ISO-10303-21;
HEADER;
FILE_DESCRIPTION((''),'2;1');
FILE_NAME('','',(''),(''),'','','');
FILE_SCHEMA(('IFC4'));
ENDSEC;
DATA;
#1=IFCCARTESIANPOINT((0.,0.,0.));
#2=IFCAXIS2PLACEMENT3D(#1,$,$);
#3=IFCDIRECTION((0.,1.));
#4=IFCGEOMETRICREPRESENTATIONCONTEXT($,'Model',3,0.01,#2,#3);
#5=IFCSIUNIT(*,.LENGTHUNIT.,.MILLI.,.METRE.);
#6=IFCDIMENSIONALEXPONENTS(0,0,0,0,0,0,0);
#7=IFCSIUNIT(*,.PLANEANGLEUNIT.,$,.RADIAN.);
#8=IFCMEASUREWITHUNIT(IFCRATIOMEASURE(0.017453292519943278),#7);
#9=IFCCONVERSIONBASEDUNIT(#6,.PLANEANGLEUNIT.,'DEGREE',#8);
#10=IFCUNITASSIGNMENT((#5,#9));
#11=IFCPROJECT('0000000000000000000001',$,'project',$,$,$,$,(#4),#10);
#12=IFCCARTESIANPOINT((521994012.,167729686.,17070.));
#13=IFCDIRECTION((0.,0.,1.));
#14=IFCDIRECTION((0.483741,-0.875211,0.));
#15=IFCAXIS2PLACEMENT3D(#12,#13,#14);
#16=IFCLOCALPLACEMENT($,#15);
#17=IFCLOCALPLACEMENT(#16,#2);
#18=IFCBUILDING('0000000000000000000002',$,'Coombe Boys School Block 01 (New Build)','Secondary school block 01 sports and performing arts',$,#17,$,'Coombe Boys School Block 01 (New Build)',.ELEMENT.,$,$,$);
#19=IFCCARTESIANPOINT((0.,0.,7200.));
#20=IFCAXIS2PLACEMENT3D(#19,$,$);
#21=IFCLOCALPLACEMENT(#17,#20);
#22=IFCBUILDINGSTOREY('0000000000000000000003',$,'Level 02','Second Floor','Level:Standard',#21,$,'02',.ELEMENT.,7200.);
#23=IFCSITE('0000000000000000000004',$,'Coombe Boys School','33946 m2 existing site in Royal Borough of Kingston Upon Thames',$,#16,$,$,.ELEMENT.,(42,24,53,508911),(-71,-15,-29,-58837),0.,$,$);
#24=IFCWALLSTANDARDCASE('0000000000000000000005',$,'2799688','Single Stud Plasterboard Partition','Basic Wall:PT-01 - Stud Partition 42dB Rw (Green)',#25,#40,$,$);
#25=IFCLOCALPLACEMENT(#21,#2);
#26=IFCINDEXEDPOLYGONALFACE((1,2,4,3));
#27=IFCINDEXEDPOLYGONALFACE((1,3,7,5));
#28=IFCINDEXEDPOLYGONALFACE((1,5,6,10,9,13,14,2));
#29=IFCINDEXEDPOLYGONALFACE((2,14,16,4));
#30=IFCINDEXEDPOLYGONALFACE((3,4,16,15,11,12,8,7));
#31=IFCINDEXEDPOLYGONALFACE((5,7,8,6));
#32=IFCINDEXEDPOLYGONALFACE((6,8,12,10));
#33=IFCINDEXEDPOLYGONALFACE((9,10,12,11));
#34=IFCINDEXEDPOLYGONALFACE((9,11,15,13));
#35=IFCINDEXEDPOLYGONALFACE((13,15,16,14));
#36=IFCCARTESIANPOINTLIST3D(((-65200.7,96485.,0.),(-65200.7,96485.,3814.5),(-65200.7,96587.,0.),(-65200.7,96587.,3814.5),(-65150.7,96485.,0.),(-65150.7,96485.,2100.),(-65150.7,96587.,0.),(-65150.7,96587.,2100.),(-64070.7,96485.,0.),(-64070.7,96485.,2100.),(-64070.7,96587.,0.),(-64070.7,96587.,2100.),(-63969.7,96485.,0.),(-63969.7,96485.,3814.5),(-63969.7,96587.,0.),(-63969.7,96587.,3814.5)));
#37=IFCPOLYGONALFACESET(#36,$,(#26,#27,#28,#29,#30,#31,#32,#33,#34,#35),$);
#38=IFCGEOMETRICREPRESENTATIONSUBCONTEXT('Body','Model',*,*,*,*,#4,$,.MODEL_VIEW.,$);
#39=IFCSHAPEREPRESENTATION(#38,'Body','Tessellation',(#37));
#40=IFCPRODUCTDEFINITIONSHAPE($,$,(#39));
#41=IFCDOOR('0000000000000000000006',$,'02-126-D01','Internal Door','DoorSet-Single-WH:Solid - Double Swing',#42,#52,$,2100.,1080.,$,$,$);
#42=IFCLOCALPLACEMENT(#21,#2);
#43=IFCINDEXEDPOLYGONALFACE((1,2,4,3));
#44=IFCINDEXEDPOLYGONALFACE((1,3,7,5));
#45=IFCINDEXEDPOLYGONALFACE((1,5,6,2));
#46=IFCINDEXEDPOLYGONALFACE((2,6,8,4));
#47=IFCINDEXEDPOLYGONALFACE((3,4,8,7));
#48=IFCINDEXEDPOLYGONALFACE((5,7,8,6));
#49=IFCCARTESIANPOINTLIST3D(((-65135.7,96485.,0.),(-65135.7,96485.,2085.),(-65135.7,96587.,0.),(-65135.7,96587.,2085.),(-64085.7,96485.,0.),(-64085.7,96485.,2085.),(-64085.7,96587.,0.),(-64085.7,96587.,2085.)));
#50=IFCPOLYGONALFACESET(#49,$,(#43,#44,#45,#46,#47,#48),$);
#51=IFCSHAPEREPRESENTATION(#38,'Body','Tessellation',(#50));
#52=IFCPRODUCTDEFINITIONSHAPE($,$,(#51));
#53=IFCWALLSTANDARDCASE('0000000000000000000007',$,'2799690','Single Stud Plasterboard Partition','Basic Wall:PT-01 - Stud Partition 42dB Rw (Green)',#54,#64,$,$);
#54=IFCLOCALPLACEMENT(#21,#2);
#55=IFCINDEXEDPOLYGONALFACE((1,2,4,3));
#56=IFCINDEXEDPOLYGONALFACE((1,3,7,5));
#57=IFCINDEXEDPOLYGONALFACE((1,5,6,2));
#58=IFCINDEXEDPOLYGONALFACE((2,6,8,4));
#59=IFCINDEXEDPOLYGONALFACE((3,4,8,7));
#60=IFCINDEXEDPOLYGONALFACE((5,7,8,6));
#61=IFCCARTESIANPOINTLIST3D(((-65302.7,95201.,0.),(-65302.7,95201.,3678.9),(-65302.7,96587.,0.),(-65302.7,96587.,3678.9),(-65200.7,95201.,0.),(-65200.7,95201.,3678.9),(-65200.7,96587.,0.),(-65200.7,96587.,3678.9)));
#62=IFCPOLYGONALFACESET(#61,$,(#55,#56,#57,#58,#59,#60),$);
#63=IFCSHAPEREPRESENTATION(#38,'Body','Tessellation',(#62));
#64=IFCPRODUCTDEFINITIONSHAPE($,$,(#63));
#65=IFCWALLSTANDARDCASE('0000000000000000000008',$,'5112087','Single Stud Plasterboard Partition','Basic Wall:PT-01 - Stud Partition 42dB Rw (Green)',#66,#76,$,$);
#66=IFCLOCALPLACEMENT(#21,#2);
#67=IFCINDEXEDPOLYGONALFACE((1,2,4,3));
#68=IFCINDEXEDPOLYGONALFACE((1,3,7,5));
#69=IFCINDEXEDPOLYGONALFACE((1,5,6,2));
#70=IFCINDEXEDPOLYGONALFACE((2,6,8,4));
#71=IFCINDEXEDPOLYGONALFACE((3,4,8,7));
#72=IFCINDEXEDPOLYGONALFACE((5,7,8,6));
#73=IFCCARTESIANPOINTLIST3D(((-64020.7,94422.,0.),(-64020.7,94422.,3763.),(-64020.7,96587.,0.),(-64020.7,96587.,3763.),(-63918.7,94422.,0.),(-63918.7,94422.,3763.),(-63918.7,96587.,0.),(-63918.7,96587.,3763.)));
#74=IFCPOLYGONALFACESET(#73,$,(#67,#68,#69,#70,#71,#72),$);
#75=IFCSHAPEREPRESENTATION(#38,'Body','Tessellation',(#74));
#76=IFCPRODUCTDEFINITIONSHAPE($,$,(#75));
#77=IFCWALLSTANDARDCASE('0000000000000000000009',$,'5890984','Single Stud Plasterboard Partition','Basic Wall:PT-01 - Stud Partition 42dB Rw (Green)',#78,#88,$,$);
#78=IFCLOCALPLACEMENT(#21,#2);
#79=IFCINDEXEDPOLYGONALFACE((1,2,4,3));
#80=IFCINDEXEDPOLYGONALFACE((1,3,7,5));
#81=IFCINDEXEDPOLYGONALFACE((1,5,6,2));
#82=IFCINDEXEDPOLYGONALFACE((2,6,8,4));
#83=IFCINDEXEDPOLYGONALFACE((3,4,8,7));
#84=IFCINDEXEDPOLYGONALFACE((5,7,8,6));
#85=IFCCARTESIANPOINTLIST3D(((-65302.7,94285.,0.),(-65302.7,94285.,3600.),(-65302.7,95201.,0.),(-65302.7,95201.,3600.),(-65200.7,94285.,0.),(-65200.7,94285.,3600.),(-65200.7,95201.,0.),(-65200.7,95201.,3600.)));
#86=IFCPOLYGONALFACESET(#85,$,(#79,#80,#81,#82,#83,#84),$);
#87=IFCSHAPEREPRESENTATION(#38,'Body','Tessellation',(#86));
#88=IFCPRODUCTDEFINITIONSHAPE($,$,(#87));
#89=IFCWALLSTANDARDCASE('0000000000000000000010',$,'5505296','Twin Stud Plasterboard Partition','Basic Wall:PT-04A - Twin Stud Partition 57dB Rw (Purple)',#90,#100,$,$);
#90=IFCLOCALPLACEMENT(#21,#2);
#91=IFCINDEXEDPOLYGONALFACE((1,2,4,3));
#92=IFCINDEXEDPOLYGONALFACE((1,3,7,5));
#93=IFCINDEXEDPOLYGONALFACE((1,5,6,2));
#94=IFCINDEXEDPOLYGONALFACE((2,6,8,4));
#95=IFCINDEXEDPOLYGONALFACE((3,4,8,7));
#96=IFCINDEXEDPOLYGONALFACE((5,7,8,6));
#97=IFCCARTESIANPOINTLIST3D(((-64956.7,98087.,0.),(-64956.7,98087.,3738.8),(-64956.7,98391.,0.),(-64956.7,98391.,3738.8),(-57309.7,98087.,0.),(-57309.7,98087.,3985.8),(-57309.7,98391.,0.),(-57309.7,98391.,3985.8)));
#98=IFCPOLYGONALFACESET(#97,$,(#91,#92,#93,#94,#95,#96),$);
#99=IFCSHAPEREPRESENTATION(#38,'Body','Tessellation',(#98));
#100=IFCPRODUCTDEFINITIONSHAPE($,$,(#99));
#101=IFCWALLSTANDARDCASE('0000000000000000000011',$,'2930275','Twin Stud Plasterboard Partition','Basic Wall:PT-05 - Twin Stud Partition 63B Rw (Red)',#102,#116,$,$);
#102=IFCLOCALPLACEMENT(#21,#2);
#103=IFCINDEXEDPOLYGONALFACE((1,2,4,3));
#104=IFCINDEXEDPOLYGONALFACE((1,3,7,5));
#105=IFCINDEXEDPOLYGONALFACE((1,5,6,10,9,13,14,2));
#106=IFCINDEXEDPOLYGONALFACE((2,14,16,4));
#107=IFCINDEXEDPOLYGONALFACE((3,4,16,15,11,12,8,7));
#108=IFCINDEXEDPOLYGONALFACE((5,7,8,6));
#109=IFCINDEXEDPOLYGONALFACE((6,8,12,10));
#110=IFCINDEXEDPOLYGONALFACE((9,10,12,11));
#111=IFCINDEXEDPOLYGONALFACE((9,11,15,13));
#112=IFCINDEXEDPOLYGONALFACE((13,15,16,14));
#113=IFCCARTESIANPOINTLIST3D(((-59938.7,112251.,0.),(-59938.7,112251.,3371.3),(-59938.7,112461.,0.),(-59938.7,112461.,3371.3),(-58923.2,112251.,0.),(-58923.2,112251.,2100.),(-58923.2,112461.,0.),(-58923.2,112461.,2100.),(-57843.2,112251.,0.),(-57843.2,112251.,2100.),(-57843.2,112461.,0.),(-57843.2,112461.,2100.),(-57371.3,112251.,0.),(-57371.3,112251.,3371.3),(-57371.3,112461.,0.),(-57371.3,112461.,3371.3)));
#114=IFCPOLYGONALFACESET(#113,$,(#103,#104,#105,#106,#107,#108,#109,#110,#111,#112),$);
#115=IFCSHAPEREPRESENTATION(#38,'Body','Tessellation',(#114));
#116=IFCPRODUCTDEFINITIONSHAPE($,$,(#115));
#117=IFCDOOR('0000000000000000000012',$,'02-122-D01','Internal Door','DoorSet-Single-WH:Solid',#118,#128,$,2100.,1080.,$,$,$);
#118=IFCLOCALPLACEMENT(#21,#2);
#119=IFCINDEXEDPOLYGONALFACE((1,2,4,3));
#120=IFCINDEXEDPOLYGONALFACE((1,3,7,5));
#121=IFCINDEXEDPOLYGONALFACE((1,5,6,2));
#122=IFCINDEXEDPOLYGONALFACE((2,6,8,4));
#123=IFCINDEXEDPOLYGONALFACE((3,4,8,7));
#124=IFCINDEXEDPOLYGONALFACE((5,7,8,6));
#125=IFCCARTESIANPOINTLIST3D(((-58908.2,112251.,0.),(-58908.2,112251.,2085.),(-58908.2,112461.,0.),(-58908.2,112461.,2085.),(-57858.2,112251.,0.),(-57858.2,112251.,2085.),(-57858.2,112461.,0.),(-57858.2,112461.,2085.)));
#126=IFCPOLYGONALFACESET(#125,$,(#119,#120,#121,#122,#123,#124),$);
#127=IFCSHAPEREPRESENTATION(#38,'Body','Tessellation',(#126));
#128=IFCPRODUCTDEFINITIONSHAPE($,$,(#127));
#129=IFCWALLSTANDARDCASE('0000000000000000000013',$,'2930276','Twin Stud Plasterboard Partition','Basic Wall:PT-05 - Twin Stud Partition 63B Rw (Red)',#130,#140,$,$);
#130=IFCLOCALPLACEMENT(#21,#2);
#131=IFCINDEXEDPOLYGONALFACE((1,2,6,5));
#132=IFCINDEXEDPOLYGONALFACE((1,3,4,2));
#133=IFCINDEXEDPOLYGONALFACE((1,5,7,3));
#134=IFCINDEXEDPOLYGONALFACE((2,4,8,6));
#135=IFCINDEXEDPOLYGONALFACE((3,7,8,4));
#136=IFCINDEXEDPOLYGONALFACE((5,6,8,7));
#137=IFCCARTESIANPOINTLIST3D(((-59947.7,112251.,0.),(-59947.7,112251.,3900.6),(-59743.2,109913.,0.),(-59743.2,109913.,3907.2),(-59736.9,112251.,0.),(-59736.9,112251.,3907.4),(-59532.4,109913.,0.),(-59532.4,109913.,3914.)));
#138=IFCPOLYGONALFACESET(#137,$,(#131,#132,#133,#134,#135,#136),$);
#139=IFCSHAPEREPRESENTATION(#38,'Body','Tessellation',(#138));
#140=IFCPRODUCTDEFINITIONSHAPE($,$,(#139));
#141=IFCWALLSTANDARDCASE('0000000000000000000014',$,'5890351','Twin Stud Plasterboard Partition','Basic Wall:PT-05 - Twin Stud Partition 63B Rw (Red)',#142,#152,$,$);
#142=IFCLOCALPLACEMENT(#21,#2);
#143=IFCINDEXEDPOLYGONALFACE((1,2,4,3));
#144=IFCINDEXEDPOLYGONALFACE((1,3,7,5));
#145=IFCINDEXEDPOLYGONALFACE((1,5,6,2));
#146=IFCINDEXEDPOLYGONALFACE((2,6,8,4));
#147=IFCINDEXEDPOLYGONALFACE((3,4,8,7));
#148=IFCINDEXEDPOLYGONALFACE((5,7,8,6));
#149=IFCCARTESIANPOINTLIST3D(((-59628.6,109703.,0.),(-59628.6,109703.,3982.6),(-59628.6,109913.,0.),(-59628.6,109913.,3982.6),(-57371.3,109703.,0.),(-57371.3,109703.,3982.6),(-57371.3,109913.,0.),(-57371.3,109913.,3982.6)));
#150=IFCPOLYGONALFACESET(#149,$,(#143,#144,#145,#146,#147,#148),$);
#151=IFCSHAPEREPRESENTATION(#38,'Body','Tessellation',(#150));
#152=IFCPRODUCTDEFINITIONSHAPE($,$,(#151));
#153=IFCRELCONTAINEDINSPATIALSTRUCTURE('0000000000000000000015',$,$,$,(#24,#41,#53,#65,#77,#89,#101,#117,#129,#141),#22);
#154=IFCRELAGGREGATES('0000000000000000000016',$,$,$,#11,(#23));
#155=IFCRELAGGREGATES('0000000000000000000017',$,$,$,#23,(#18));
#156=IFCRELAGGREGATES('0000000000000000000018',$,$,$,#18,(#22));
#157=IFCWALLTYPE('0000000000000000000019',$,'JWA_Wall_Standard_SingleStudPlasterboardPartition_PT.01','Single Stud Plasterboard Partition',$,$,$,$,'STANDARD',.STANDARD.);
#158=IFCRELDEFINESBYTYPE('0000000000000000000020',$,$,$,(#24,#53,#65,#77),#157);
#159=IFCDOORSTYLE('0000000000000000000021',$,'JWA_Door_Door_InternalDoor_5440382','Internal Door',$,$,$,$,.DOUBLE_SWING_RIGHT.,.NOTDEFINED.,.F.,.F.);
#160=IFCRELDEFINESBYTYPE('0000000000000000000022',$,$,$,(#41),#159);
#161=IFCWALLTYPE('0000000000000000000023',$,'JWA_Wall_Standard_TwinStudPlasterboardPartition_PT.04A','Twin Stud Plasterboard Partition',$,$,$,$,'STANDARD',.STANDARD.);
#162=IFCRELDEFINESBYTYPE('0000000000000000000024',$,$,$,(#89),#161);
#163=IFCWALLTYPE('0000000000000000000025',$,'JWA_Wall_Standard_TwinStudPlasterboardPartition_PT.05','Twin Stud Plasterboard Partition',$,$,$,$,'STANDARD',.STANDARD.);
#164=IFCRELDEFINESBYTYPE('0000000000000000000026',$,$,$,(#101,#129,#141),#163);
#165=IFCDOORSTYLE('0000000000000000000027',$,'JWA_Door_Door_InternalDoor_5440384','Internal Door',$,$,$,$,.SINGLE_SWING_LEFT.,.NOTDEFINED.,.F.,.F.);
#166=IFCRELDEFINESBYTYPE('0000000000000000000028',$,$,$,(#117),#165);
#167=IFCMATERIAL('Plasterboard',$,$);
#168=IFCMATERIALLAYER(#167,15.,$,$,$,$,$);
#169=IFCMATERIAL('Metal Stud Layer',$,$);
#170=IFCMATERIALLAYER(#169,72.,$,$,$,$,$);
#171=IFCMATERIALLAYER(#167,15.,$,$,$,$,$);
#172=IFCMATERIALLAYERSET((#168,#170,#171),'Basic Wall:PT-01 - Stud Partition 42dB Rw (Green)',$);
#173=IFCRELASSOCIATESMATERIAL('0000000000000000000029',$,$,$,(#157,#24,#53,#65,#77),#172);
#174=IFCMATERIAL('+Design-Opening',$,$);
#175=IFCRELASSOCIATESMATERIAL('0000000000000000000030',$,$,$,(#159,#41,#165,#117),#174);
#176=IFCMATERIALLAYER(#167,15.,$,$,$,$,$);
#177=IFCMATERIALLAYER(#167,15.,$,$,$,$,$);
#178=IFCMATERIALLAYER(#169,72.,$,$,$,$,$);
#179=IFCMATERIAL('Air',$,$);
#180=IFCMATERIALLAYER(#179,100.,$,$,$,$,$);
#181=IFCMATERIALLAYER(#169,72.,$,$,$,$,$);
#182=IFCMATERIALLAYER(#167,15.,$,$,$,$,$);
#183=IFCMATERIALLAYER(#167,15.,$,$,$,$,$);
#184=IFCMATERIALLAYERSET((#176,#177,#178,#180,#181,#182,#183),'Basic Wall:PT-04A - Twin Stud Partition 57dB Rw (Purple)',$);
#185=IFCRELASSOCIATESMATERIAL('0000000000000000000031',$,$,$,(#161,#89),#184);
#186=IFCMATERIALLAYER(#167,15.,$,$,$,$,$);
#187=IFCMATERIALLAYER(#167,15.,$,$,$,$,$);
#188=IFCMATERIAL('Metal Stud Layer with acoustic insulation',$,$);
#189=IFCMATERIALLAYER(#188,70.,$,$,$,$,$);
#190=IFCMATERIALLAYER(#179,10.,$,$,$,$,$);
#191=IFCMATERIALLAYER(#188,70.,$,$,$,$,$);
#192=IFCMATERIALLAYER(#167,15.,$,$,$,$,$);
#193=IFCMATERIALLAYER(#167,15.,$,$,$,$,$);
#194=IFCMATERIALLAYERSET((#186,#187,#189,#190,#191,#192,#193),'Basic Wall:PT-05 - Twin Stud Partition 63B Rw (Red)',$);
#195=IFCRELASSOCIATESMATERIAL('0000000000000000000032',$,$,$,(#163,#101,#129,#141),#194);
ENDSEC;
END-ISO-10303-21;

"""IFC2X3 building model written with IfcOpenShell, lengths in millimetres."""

from ifc_helpers import new_model, entity, si_unit, converted_unit, direction, frame, frame_2d, origin, origin_2d_with_axis, place, context, subcontext, project, spatial, polyline, rectangle, outline, extrude, clip, bounded_halfspace, source, transform, mapped, material, layer, layer_set, layer_usage, type_object, type_shapes, element, fill, save


model = new_model("IFC2X3")

# Units and contexts
model_context = context("Model", 3, precision=0.01, world=origin(), true_north=direction((0.0, 1.0)))
body_context = subcontext(model_context, "Body", "Model", "MODEL_VIEW")
ifc_project = project(units=[si_unit("LENGTHUNIT", "METRE", prefix="MILLI"), converted_unit("PLANEANGLEUNIT", "DEGREE", entity("IfcRatioMeasure", 0.017453292519943278), si_unit("PLANEANGLEUNIT", "RADIAN"), dimensions=[0, 0, 0, 0, 0, 0, 0])], contexts=[model_context])

# Site, building, storey
site_placement = place(None, frame((521994012.0, 167729686.0, 17070.0), z_axis=(0.0, 0.0, 1.0), x_axis=(0.483741, -0.875211, 0.0)))
site = spatial("IfcSite", under=ifc_project, at=site_placement, Name="Coombe Boys School", Description="33946 m2 existing site in Royal Borough of Kingston Upon Thames", CompositionType="ELEMENT", RefLatitude=(42, 24, 53, 508911), RefLongitude=(-71, -15, -29, -58837), RefElevation=0.0)
building_placement = place(site_placement, origin())
building = spatial("IfcBuilding", under=site, at=building_placement, Name="Coombe Boys School Block 01 (New Build)", Description="Secondary school block 01 sports and performing arts", LongName="Coombe Boys School Block 01 (New Build)", CompositionType="ELEMENT")
storey_placement = place(building_placement, frame((0.0, 0.0, 7200.0)))
storey = spatial("IfcBuildingStorey", under=building, at=storey_placement, Name="Level 02", Description="Second Floor", ObjectType="Level:Standard", LongName="02", CompositionType="ELEMENT", Elevation=7200.0)

# Wall, opening, door
ifc_material_1 = material(Name="Plasterboard")
ifc_layer_1 = layer(ifc_material_1, 15.0)
ifc_material_2 = material(Name="Metal Stud Layer")
ifc_layer_2 = layer(ifc_material_2, 72.0)
ifc_layer_3 = layer(ifc_material_1, 15.0)
ifc_layer_set_1 = layer_set([ifc_layer_1, ifc_layer_2, ifc_layer_3], Name="Basic Wall:PT-01 - Stud Partition 42dB Rw (Green)")
ifc_layer_usage_1 = layer_usage(ifc_layer_set_1, "AXIS2", "NEGATIVE", 51.0)
wall_type_1 = type_object("IfcWallType", Name="JWA_Wall_Standard_SingleStudPlasterboardPartition_PT.01", Description="Single Stud Plasterboard Partition", ElementType="STANDARD", PredefinedType="STANDARD", material=ifc_layer_set_1)
wall_1_placement = place(storey_placement, frame((-65200.7, 96536.0, 0.0)))
wall_1 = element("IfcWallStandardCase", 1, at=wall_1_placement, inside=storey, type_object=wall_type_1, material=ifc_layer_usage_1, Name="2799688", Description="Single Stud Plasterboard Partition", ObjectType="Basic Wall:PT-01 - Stud Partition 42dB Rw (Green)", context=body_context, shape_type="SweptSolid", body=[
    extrude(rectangle(XDim=1231.0, YDim=102.0, at=frame_2d((615.5, 0.0), x_axis=(-1.0, 0.0))), origin(), (0.0, 0.0, 1.0), 3814.5),
])
opening_1_placement = place(wall_1_placement, frame((65200.7, -96536.0, 0.0)))
opening_1 = element("IfcOpeningElement", 2, at=opening_1_placement, cuts=wall_1, ObjectType="Opening", context=body_context, shape_type="SweptSolid", body=[
    extrude(rectangle(XDim=2100.0, YDim=1080.0, at=frame_2d((0.0, 0.0), x_axis=(0.0, 1.0))), frame((-64610.7, 96485.0, 1050.0), z_axis=(0.0, 1.0, 0.0), x_axis=(1.0, 0.0, 0.0)), (0.0, 0.0, 1.0), 102.0),
])
ifc_material_3 = material(Name="+Design-Opening")
door_style_1 = type_object("IfcDoorStyle", Name="JWA_Door_Door_InternalDoor_5440382", Description="Internal Door", ConstructionType="NOTDEFINED", OperationType="DOUBLE_SWING_RIGHT", ParameterTakesPrecedence=False, Sizeable=False, material=ifc_material_3)
shared_shape_1 = source(origin(), body_context, "Body", "SweptSolid", [
    extrude(rectangle(XDim=102.0, YDim=1050.0, at=origin_2d_with_axis()), frame((125.0, 0.0, 0.0), z_axis=(0.0, 0.0, 1.0), x_axis=(0.0, 1.0, 0.0)), (0.0, 0.0, 1.0), 2085.0),
])
type_shapes(door_style_1, [shared_shape_1])
door_1_placement = place(opening_1_placement, frame((-64485.7, 96536.0, 0.0), z_axis=(0.0, 0.0, 1.0), x_axis=(-1.0, 0.0, 0.0)))
door_1 = element("IfcDoor", 3, at=door_1_placement, inside=storey, type_object=door_style_1, material=ifc_material_3, Name="02-126-D01", Description="Internal Door", ObjectType="DoorSet-Single-WH:Solid - Double Swing", OverallHeight=2100.0, OverallWidth=1080.0, context=body_context, shape_type="MappedRepresentation", body=[
    mapped(shared_shape_1, transform((0.0, 0.0, 0.0), scale=1.0)),
])
fill(opening_1, door_1)

# Walls
wall_2_placement = place(storey_placement, frame((-65251.7, 96587.0, 0.0), z_axis=(0.0, 0.0, 1.0), x_axis=(0.0, -1.0, 0.0)))
element("IfcWallStandardCase", 4, at=wall_2_placement, inside=storey, type_object=wall_type_1, material=ifc_layer_usage_1, Name="2799690", Description="Single Stud Plasterboard Partition", ObjectType="Basic Wall:PT-01 - Stud Partition 42dB Rw (Green)", context=body_context, shape_type="SweptSolid", body=[
    extrude(rectangle(XDim=1386.0, YDim=102.0, at=frame_2d((693.0, 0.0), x_axis=(-1.0, 0.0))), origin(), (0.0, 0.0, 1.0), 3678.9),
])
wall_3_placement = place(storey_placement, frame((-63969.7, 96587.0, 0.0), z_axis=(0.0, 0.0, 1.0), x_axis=(0.0, -1.0, 0.0)))
element("IfcWallStandardCase", 5, at=wall_3_placement, inside=storey, type_object=wall_type_1, material=ifc_layer_usage_1, Name="5112087", Description="Single Stud Plasterboard Partition", ObjectType="Basic Wall:PT-01 - Stud Partition 42dB Rw (Green)", context=body_context, shape_type="SweptSolid", body=[
    extrude(rectangle(XDim=2165.0, YDim=102.0, at=frame_2d((1082.5, 0.0), x_axis=(-1.0, 0.0))), origin(), (0.0, 0.0, 1.0), 3763.0),
])

# Walls
wall_4_placement = place(storey_placement, frame((-65251.7, 95201.0, 0.0), z_axis=(0.0, 0.0, 1.0), x_axis=(0.0, -1.0, 0.0)))
element("IfcWallStandardCase", 6, at=wall_4_placement, inside=storey, type_object=wall_type_1, material=ifc_layer_usage_1, Name="5890984", Description="Single Stud Plasterboard Partition", ObjectType="Basic Wall:PT-01 - Stud Partition 42dB Rw (Green)", context=body_context, shape_type="SweptSolid", body=[
    extrude(rectangle(XDim=916.0, YDim=102.0, at=frame_2d((458.0, 0.0), x_axis=(-1.0, 0.0))), origin(), (0.0, 0.0, 1.0), 3600.0),
])
ifc_layer_4 = layer(ifc_material_1, 15.0)
ifc_layer_5 = layer(ifc_material_1, 15.0)
ifc_layer_6 = layer(ifc_material_2, 72.0)
ifc_material_4 = material(Name="Air")
ifc_layer_7 = layer(ifc_material_4, 100.0)
ifc_layer_8 = layer(ifc_material_2, 72.0)
ifc_layer_9 = layer(ifc_material_1, 15.0)
ifc_layer_10 = layer(ifc_material_1, 15.0)
ifc_layer_set_2 = layer_set([ifc_layer_4, ifc_layer_5, ifc_layer_6, ifc_layer_7, ifc_layer_8, ifc_layer_9, ifc_layer_10], Name="Basic Wall:PT-04A - Twin Stud Partition 57dB Rw (Purple)")
ifc_layer_usage_2 = layer_usage(ifc_layer_set_2, "AXIS2", "NEGATIVE", 152.0)
wall_type_2 = type_object("IfcWallType", Name="JWA_Wall_Standard_TwinStudPlasterboardPartition_PT.04A", Description="Twin Stud Plasterboard Partition", ElementType="STANDARD", PredefinedType="STANDARD", material=ifc_layer_set_2)
wall_5_placement = place(storey_placement, frame((-64956.7, 98239.0, 0.0)))
element("IfcWallStandardCase", 7, at=wall_5_placement, inside=storey, type_object=wall_type_2, material=ifc_layer_usage_2, Name="5505296", Description="Twin Stud Plasterboard Partition", ObjectType="Basic Wall:PT-04A - Twin Stud Partition 57dB Rw (Purple)", context=body_context, shape_type="Clipping", body=[
    clip(extrude(rectangle(XDim=7647.0, YDim=304.0, at=frame_2d((3823.5, 0.0), x_axis=(-1.0, 0.0))), origin(), (0.0, 0.0, 1.0), 3985.8), bounded_halfspace(frame((0.0, -152.0, 3738.8), z_axis=(-0.032283, 0.0, 0.999479), x_axis=(0.0, -1.0, 0.0)), False, frame((0.0, -152.0, 3738.8)), polyline([(0.0, 0.0), (7647.0, 0.0), (7647.0, 304.0), (0.0, 304.0), (0.0, 0.0)]))),
])

# Wall, opening, door
ifc_layer_11 = layer(ifc_material_1, 15.0)
ifc_layer_12 = layer(ifc_material_1, 15.0)
ifc_material_5 = material(Name="Metal Stud Layer with acoustic insulation")
ifc_layer_13 = layer(ifc_material_5, 70.0)
ifc_layer_14 = layer(ifc_material_4, 10.0)
ifc_layer_15 = layer(ifc_material_5, 70.0)
ifc_layer_16 = layer(ifc_material_1, 15.0)
ifc_layer_17 = layer(ifc_material_1, 15.0)
ifc_layer_set_3 = layer_set([ifc_layer_11, ifc_layer_12, ifc_layer_13, ifc_layer_14, ifc_layer_15, ifc_layer_16, ifc_layer_17], Name="Basic Wall:PT-05 - Twin Stud Partition 63B Rw (Red)")
ifc_layer_usage_3 = layer_usage(ifc_layer_set_3, "AXIS2", "NEGATIVE", 105.0)
wall_type_3 = type_object("IfcWallType", Name="JWA_Wall_Standard_TwinStudPlasterboardPartition_PT.05", Description="Twin Stud Plasterboard Partition", ElementType="STANDARD", PredefinedType="STANDARD", material=ifc_layer_set_3)
wall_6_placement = place(storey_placement, frame((-57371.3, 112356.0, 0.0), z_axis=(0.0, 0.0, 1.0), x_axis=(-1.0, 0.0, 0.0)))
wall_6 = element("IfcWallStandardCase", 8, at=wall_6_placement, inside=storey, type_object=wall_type_3, material=ifc_layer_usage_3, Name="2930275", Description="Twin Stud Plasterboard Partition", ObjectType="Basic Wall:PT-05 - Twin Stud Partition 63B Rw (Red)", context=body_context, shape_type="SweptSolid", body=[
    extrude(rectangle(XDim=2567.4, YDim=210.0, at=frame_2d((1283.7, 0.0), x_axis=(1.0, 0.0))), origin(), (0.0, 0.0, 1.0), 3371.3),
])
opening_2_placement = place(wall_6_placement, frame((-57371.3, 112356.0, 0.0), z_axis=(0.0, 0.0, 1.0), x_axis=(-1.0, 0.0, 0.0)))
opening_2 = element("IfcOpeningElement", 9, at=opening_2_placement, cuts=wall_6, ObjectType="Opening", context=body_context, shape_type="SweptSolid", body=[
    extrude(rectangle(XDim=2100.0, YDim=1080.0, at=frame_2d((0.0, 0.0), x_axis=(0.0, 1.0))), frame((-58383.2, 112461.0, 1050.0), z_axis=(0.0, -1.0, 0.0), x_axis=(-1.0, 0.0, 0.0)), (0.0, 0.0, 1.0), 210.0),
])
door_style_2 = type_object("IfcDoorStyle", Name="JWA_Door_Door_InternalDoor_5440384", Description="Internal Door", ConstructionType="NOTDEFINED", OperationType="SINGLE_SWING_LEFT", ParameterTakesPrecedence=False, Sizeable=False, material=ifc_material_3)
shared_shape_2 = source(origin(), body_context, "Body", "SweptSolid", [
    extrude(rectangle(XDim=1050.0, YDim=210.0, at=origin_2d_with_axis()), frame((125.0, 0.0, 0.0), z_axis=(0.0, 0.0, 1.0), x_axis=(-1.0, 0.0, 0.0)), (0.0, 0.0, 1.0), 2085.0),
])
type_shapes(door_style_2, [shared_shape_2])
door_2_placement = place(opening_2_placement, frame((-58508.2, 112356.0, 0.0)))
door_2 = element("IfcDoor", 10, at=door_2_placement, inside=storey, type_object=door_style_2, material=ifc_material_3, Name="02-122-D01", Description="Internal Door", ObjectType="DoorSet-Single-WH:Solid", OverallHeight=2100.0, OverallWidth=1080.0, context=body_context, shape_type="MappedRepresentation", body=[
    mapped(shared_shape_2, transform((0.0, 0.0, 0.0), scale=1.0)),
])
fill(opening_2, door_2)

# Walls
wall_7_placement = place(storey_placement, frame((-59843.1, 112260.1, 0.0), z_axis=(0.0, 0.0, 1.0), x_axis=(0.087156, -0.996195, 0.0)))
element("IfcWallStandardCase", 11, at=wall_7_placement, inside=storey, type_object=wall_type_3, material=ifc_layer_usage_3, Name="2930276", Description="Twin Stud Plasterboard Partition", ObjectType="Basic Wall:PT-05 - Twin Stud Partition 63B Rw (Red)", context=body_context, shape_type="Clipping", body=[
    clip(extrude(outline(polyline([(2346.9, -105.0), (2356.9, 9.2), (2365.3, 105.0), (18.4, 105.0), (0.8, -96.1), (0.0, -105.0), (2346.9, -105.0)])), origin(), (0.0, 0.0, 1.0), 3914.0), bounded_halfspace(frame((0.0, -105.0, 3900.6), z_axis=(-0.002814, -0.03216, 0.999479), x_axis=(0.996195, -0.087156, 0.0)), False, frame((0.0, -105.0, 3900.6)), polyline([(0.0, 0.0), (2346.9, 0.0), (2356.9, 114.2), (2365.3, 210.0), (18.4, 210.0), (0.0, 0.0)]))),
])
wall_8_placement = place(storey_placement, frame((-59628.6, 109808.0, 0.0)))
element("IfcWallStandardCase", 12, at=wall_8_placement, inside=storey, type_object=wall_type_3, material=ifc_layer_usage_3, Name="5890351", Description="Twin Stud Plasterboard Partition", ObjectType="Basic Wall:PT-05 - Twin Stud Partition 63B Rw (Red)", context=body_context, shape_type="SweptSolid", body=[
    extrude(rectangle(XDim=2257.2, YDim=210.0, at=frame_2d((1128.6, 0.0), x_axis=(-1.0, 0.0))), origin(), (0.0, 0.0, 1.0), 3982.6),
])

save(model, "model.ifc")
